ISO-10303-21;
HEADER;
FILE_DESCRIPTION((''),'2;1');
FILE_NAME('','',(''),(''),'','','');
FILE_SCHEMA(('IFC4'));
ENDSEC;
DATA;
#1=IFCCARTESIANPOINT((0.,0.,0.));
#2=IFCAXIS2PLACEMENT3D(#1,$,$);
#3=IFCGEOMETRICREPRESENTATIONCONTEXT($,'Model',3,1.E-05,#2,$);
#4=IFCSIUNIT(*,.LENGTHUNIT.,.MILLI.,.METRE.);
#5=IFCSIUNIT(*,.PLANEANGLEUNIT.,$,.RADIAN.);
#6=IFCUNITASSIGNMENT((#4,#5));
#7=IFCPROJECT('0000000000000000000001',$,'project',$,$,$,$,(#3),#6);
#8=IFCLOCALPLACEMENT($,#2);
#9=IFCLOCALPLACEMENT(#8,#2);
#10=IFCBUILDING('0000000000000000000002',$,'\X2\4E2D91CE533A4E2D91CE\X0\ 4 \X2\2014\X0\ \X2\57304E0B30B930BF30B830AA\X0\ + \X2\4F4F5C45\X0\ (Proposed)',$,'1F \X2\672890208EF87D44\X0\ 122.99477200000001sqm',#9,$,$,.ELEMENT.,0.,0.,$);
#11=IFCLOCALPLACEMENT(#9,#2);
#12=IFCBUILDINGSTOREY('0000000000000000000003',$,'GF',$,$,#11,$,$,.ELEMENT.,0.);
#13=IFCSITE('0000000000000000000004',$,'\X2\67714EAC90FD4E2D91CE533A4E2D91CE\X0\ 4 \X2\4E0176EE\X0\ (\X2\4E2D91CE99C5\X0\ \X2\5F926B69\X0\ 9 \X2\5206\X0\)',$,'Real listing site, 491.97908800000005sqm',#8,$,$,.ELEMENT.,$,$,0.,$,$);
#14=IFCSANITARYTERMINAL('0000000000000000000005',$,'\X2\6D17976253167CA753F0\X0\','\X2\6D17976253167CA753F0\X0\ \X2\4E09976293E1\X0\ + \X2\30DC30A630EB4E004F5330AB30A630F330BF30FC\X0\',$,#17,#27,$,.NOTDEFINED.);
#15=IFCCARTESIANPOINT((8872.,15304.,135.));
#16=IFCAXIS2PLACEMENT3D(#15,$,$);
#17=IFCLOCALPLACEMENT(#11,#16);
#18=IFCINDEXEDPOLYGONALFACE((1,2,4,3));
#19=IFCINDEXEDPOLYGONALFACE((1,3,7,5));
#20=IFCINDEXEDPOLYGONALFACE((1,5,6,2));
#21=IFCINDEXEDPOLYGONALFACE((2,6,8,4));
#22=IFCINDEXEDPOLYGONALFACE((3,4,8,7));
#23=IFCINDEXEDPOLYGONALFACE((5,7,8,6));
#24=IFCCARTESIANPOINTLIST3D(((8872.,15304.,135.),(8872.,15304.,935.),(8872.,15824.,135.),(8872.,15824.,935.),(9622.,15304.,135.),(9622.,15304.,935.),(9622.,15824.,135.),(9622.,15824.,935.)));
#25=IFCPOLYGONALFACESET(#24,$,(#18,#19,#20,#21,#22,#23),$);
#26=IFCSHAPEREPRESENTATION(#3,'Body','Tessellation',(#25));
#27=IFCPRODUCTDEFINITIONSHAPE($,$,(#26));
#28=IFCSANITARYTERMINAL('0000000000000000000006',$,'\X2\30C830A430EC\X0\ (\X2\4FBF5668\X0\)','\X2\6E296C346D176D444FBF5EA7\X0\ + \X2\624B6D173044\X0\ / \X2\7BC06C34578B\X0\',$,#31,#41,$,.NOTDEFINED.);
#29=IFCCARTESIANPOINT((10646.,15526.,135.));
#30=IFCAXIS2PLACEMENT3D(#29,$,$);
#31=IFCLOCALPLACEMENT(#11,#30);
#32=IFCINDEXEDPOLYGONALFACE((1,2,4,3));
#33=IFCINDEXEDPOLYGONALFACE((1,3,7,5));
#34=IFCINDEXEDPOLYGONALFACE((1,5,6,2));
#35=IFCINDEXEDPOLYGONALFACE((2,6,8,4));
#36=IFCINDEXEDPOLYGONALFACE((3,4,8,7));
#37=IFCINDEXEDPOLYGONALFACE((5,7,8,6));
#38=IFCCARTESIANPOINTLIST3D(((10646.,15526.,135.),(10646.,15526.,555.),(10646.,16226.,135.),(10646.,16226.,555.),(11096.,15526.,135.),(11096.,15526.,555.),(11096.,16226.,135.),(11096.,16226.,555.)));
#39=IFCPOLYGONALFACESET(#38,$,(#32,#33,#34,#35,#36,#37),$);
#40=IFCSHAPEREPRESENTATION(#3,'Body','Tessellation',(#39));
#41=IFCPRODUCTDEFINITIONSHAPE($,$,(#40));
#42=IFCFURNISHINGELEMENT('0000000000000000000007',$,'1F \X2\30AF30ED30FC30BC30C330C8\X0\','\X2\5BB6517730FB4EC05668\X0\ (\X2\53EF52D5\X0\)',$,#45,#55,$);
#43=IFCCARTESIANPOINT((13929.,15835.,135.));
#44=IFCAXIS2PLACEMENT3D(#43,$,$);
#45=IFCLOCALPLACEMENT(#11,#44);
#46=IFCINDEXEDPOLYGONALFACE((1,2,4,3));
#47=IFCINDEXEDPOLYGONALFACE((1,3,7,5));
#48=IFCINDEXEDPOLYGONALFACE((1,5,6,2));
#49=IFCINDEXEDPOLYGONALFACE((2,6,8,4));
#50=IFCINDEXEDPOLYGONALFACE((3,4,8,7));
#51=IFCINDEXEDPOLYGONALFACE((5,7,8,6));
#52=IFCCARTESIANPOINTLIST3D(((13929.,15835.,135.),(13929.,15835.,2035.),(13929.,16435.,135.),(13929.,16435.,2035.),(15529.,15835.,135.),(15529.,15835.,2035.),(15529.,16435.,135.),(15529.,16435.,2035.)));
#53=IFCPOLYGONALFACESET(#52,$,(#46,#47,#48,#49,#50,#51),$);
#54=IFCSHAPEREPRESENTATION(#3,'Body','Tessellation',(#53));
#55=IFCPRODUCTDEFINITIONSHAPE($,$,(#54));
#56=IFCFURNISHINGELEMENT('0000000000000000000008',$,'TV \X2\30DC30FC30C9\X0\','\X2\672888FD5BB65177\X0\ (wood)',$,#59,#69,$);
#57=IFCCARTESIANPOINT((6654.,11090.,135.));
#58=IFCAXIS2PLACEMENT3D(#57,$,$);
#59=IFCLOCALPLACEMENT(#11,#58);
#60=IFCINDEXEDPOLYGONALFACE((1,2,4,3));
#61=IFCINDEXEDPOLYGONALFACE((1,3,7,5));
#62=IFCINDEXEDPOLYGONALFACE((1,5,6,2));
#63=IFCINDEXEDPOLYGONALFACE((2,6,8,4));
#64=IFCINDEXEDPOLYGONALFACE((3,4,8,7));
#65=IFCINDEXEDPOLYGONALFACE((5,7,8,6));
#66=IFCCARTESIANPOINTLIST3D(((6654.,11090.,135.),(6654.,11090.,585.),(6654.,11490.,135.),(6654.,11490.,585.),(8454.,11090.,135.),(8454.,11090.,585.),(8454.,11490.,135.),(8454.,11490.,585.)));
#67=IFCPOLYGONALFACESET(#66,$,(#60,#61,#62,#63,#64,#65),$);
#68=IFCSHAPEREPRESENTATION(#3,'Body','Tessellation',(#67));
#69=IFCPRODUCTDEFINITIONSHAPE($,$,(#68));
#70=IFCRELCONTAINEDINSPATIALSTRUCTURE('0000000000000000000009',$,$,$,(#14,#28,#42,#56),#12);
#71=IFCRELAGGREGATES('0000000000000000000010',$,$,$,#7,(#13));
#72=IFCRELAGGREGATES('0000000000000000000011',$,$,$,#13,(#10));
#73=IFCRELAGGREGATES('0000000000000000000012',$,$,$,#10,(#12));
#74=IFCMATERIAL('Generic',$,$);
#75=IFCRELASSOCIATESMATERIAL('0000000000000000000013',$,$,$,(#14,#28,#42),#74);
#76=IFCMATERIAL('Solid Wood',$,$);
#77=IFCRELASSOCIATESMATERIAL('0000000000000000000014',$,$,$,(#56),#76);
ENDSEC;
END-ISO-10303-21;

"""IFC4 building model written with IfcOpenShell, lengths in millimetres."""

from ifc_helpers import new_model, si_unit, frame, frame_2d, origin, place, context, project, spatial, rectangle, extrude, material, element, save


model = new_model("IFC4")

# Units and contexts
model_context = context("Model", 3, precision=1e-05, world=origin())
ifc_project = project(units=[si_unit("LENGTHUNIT", "METRE", prefix="MILLI"), si_unit("PLANEANGLEUNIT", "RADIAN")], contexts=[model_context])

# Site, building, storey
site_placement = place(None, origin())
site = spatial("IfcSite", under=ifc_project, at=site_placement, Name="東京都中野区中野 4 丁目 (中野駅 徒歩 9 分)", ObjectType="Real listing site, 491.97908800000005sqm", CompositionType="ELEMENT", RefElevation=0.0)
building_placement = place(site_placement, origin())
building = spatial("IfcBuilding", under=site, at=building_placement, Name="中野区中野 4 — 地下スタジオ + 住居 (Proposed)", ObjectType="1F 木造軸組 122.99477200000001sqm", CompositionType="ELEMENT", ElevationOfRefHeight=0.0, ElevationOfTerrain=0.0)
storey_placement = place(building_placement, origin())
storey = spatial("IfcBuildingStorey", under=building, at=storey_placement, Name="GF", CompositionType="ELEMENT", Elevation=0.0)

# Shared definitions
ifc_material_1 = material(Name="Solid Wood")

# Sanitary terminals
ifc_material_2 = material(Name="Generic")
sanitary_terminal_1_placement = place(storey_placement, frame((8872.0, 15304.0, 135.0)))
element("IfcSanitaryTerminal", 1, at=sanitary_terminal_1_placement, inside=storey, material=ifc_material_2, Name="洗面化粧台", Description="洗面化粧台 三面鏡 + ボウル一体カウンター", PredefinedType="NOTDEFINED", context=model_context, shape_type="SweptSolid", body=[
    extrude(rectangle(XDim=750.0, YDim=520.0, at=frame_2d((375.0, 260.0))), frame((8872.0, 15304.0, 135.0)), (0.0, 0.0, 1.0), 800.0),
])
sanitary_terminal_2_placement = place(storey_placement, frame((10646.0, 15526.0, 135.0)))
element("IfcSanitaryTerminal", 2, at=sanitary_terminal_2_placement, inside=storey, material=ifc_material_2, Name="トイレ (便器)", Description="温水洗浄便座 + 手洗い / 節水型", PredefinedType="NOTDEFINED", context=model_context, shape_type="SweptSolid", body=[
    extrude(rectangle(XDim=450.0, YDim=700.0, at=frame_2d((225.0, 350.0))), frame((10646.0, 15526.0, 135.0)), (0.0, 0.0, 1.0), 420.0),
])

# Furnishing elements
furnishing_1_placement = place(storey_placement, frame((13929.0, 15835.0, 135.0)))
element("IfcFurnishingElement", 3, at=furnishing_1_placement, inside=storey, material=ifc_material_2, Name="1F クローゼット", Description="家具・什器 (可動)", context=model_context, shape_type="SweptSolid", body=[
    extrude(rectangle(XDim=1600.0, YDim=600.0, at=frame_2d((800.0, 300.0))), frame((13929.0, 15835.0, 135.0)), (0.0, 0.0, 1.0), 1900.0),
])
furnishing_2_placement = place(storey_placement, frame((6654.0, 11090.0, 135.0)))
element("IfcFurnishingElement", 4, at=furnishing_2_placement, inside=storey, material=ifc_material_1, Name="TV ボード", Description="木製家具 (wood)", context=model_context, shape_type="SweptSolid", body=[
    extrude(rectangle(XDim=1800.0, YDim=400.0, at=frame_2d((900.0, 200.0))), frame((6654.0, 11090.0, 135.0)), (0.0, 0.0, 1.0), 450.0),
])

save(model, "model.ifc")
